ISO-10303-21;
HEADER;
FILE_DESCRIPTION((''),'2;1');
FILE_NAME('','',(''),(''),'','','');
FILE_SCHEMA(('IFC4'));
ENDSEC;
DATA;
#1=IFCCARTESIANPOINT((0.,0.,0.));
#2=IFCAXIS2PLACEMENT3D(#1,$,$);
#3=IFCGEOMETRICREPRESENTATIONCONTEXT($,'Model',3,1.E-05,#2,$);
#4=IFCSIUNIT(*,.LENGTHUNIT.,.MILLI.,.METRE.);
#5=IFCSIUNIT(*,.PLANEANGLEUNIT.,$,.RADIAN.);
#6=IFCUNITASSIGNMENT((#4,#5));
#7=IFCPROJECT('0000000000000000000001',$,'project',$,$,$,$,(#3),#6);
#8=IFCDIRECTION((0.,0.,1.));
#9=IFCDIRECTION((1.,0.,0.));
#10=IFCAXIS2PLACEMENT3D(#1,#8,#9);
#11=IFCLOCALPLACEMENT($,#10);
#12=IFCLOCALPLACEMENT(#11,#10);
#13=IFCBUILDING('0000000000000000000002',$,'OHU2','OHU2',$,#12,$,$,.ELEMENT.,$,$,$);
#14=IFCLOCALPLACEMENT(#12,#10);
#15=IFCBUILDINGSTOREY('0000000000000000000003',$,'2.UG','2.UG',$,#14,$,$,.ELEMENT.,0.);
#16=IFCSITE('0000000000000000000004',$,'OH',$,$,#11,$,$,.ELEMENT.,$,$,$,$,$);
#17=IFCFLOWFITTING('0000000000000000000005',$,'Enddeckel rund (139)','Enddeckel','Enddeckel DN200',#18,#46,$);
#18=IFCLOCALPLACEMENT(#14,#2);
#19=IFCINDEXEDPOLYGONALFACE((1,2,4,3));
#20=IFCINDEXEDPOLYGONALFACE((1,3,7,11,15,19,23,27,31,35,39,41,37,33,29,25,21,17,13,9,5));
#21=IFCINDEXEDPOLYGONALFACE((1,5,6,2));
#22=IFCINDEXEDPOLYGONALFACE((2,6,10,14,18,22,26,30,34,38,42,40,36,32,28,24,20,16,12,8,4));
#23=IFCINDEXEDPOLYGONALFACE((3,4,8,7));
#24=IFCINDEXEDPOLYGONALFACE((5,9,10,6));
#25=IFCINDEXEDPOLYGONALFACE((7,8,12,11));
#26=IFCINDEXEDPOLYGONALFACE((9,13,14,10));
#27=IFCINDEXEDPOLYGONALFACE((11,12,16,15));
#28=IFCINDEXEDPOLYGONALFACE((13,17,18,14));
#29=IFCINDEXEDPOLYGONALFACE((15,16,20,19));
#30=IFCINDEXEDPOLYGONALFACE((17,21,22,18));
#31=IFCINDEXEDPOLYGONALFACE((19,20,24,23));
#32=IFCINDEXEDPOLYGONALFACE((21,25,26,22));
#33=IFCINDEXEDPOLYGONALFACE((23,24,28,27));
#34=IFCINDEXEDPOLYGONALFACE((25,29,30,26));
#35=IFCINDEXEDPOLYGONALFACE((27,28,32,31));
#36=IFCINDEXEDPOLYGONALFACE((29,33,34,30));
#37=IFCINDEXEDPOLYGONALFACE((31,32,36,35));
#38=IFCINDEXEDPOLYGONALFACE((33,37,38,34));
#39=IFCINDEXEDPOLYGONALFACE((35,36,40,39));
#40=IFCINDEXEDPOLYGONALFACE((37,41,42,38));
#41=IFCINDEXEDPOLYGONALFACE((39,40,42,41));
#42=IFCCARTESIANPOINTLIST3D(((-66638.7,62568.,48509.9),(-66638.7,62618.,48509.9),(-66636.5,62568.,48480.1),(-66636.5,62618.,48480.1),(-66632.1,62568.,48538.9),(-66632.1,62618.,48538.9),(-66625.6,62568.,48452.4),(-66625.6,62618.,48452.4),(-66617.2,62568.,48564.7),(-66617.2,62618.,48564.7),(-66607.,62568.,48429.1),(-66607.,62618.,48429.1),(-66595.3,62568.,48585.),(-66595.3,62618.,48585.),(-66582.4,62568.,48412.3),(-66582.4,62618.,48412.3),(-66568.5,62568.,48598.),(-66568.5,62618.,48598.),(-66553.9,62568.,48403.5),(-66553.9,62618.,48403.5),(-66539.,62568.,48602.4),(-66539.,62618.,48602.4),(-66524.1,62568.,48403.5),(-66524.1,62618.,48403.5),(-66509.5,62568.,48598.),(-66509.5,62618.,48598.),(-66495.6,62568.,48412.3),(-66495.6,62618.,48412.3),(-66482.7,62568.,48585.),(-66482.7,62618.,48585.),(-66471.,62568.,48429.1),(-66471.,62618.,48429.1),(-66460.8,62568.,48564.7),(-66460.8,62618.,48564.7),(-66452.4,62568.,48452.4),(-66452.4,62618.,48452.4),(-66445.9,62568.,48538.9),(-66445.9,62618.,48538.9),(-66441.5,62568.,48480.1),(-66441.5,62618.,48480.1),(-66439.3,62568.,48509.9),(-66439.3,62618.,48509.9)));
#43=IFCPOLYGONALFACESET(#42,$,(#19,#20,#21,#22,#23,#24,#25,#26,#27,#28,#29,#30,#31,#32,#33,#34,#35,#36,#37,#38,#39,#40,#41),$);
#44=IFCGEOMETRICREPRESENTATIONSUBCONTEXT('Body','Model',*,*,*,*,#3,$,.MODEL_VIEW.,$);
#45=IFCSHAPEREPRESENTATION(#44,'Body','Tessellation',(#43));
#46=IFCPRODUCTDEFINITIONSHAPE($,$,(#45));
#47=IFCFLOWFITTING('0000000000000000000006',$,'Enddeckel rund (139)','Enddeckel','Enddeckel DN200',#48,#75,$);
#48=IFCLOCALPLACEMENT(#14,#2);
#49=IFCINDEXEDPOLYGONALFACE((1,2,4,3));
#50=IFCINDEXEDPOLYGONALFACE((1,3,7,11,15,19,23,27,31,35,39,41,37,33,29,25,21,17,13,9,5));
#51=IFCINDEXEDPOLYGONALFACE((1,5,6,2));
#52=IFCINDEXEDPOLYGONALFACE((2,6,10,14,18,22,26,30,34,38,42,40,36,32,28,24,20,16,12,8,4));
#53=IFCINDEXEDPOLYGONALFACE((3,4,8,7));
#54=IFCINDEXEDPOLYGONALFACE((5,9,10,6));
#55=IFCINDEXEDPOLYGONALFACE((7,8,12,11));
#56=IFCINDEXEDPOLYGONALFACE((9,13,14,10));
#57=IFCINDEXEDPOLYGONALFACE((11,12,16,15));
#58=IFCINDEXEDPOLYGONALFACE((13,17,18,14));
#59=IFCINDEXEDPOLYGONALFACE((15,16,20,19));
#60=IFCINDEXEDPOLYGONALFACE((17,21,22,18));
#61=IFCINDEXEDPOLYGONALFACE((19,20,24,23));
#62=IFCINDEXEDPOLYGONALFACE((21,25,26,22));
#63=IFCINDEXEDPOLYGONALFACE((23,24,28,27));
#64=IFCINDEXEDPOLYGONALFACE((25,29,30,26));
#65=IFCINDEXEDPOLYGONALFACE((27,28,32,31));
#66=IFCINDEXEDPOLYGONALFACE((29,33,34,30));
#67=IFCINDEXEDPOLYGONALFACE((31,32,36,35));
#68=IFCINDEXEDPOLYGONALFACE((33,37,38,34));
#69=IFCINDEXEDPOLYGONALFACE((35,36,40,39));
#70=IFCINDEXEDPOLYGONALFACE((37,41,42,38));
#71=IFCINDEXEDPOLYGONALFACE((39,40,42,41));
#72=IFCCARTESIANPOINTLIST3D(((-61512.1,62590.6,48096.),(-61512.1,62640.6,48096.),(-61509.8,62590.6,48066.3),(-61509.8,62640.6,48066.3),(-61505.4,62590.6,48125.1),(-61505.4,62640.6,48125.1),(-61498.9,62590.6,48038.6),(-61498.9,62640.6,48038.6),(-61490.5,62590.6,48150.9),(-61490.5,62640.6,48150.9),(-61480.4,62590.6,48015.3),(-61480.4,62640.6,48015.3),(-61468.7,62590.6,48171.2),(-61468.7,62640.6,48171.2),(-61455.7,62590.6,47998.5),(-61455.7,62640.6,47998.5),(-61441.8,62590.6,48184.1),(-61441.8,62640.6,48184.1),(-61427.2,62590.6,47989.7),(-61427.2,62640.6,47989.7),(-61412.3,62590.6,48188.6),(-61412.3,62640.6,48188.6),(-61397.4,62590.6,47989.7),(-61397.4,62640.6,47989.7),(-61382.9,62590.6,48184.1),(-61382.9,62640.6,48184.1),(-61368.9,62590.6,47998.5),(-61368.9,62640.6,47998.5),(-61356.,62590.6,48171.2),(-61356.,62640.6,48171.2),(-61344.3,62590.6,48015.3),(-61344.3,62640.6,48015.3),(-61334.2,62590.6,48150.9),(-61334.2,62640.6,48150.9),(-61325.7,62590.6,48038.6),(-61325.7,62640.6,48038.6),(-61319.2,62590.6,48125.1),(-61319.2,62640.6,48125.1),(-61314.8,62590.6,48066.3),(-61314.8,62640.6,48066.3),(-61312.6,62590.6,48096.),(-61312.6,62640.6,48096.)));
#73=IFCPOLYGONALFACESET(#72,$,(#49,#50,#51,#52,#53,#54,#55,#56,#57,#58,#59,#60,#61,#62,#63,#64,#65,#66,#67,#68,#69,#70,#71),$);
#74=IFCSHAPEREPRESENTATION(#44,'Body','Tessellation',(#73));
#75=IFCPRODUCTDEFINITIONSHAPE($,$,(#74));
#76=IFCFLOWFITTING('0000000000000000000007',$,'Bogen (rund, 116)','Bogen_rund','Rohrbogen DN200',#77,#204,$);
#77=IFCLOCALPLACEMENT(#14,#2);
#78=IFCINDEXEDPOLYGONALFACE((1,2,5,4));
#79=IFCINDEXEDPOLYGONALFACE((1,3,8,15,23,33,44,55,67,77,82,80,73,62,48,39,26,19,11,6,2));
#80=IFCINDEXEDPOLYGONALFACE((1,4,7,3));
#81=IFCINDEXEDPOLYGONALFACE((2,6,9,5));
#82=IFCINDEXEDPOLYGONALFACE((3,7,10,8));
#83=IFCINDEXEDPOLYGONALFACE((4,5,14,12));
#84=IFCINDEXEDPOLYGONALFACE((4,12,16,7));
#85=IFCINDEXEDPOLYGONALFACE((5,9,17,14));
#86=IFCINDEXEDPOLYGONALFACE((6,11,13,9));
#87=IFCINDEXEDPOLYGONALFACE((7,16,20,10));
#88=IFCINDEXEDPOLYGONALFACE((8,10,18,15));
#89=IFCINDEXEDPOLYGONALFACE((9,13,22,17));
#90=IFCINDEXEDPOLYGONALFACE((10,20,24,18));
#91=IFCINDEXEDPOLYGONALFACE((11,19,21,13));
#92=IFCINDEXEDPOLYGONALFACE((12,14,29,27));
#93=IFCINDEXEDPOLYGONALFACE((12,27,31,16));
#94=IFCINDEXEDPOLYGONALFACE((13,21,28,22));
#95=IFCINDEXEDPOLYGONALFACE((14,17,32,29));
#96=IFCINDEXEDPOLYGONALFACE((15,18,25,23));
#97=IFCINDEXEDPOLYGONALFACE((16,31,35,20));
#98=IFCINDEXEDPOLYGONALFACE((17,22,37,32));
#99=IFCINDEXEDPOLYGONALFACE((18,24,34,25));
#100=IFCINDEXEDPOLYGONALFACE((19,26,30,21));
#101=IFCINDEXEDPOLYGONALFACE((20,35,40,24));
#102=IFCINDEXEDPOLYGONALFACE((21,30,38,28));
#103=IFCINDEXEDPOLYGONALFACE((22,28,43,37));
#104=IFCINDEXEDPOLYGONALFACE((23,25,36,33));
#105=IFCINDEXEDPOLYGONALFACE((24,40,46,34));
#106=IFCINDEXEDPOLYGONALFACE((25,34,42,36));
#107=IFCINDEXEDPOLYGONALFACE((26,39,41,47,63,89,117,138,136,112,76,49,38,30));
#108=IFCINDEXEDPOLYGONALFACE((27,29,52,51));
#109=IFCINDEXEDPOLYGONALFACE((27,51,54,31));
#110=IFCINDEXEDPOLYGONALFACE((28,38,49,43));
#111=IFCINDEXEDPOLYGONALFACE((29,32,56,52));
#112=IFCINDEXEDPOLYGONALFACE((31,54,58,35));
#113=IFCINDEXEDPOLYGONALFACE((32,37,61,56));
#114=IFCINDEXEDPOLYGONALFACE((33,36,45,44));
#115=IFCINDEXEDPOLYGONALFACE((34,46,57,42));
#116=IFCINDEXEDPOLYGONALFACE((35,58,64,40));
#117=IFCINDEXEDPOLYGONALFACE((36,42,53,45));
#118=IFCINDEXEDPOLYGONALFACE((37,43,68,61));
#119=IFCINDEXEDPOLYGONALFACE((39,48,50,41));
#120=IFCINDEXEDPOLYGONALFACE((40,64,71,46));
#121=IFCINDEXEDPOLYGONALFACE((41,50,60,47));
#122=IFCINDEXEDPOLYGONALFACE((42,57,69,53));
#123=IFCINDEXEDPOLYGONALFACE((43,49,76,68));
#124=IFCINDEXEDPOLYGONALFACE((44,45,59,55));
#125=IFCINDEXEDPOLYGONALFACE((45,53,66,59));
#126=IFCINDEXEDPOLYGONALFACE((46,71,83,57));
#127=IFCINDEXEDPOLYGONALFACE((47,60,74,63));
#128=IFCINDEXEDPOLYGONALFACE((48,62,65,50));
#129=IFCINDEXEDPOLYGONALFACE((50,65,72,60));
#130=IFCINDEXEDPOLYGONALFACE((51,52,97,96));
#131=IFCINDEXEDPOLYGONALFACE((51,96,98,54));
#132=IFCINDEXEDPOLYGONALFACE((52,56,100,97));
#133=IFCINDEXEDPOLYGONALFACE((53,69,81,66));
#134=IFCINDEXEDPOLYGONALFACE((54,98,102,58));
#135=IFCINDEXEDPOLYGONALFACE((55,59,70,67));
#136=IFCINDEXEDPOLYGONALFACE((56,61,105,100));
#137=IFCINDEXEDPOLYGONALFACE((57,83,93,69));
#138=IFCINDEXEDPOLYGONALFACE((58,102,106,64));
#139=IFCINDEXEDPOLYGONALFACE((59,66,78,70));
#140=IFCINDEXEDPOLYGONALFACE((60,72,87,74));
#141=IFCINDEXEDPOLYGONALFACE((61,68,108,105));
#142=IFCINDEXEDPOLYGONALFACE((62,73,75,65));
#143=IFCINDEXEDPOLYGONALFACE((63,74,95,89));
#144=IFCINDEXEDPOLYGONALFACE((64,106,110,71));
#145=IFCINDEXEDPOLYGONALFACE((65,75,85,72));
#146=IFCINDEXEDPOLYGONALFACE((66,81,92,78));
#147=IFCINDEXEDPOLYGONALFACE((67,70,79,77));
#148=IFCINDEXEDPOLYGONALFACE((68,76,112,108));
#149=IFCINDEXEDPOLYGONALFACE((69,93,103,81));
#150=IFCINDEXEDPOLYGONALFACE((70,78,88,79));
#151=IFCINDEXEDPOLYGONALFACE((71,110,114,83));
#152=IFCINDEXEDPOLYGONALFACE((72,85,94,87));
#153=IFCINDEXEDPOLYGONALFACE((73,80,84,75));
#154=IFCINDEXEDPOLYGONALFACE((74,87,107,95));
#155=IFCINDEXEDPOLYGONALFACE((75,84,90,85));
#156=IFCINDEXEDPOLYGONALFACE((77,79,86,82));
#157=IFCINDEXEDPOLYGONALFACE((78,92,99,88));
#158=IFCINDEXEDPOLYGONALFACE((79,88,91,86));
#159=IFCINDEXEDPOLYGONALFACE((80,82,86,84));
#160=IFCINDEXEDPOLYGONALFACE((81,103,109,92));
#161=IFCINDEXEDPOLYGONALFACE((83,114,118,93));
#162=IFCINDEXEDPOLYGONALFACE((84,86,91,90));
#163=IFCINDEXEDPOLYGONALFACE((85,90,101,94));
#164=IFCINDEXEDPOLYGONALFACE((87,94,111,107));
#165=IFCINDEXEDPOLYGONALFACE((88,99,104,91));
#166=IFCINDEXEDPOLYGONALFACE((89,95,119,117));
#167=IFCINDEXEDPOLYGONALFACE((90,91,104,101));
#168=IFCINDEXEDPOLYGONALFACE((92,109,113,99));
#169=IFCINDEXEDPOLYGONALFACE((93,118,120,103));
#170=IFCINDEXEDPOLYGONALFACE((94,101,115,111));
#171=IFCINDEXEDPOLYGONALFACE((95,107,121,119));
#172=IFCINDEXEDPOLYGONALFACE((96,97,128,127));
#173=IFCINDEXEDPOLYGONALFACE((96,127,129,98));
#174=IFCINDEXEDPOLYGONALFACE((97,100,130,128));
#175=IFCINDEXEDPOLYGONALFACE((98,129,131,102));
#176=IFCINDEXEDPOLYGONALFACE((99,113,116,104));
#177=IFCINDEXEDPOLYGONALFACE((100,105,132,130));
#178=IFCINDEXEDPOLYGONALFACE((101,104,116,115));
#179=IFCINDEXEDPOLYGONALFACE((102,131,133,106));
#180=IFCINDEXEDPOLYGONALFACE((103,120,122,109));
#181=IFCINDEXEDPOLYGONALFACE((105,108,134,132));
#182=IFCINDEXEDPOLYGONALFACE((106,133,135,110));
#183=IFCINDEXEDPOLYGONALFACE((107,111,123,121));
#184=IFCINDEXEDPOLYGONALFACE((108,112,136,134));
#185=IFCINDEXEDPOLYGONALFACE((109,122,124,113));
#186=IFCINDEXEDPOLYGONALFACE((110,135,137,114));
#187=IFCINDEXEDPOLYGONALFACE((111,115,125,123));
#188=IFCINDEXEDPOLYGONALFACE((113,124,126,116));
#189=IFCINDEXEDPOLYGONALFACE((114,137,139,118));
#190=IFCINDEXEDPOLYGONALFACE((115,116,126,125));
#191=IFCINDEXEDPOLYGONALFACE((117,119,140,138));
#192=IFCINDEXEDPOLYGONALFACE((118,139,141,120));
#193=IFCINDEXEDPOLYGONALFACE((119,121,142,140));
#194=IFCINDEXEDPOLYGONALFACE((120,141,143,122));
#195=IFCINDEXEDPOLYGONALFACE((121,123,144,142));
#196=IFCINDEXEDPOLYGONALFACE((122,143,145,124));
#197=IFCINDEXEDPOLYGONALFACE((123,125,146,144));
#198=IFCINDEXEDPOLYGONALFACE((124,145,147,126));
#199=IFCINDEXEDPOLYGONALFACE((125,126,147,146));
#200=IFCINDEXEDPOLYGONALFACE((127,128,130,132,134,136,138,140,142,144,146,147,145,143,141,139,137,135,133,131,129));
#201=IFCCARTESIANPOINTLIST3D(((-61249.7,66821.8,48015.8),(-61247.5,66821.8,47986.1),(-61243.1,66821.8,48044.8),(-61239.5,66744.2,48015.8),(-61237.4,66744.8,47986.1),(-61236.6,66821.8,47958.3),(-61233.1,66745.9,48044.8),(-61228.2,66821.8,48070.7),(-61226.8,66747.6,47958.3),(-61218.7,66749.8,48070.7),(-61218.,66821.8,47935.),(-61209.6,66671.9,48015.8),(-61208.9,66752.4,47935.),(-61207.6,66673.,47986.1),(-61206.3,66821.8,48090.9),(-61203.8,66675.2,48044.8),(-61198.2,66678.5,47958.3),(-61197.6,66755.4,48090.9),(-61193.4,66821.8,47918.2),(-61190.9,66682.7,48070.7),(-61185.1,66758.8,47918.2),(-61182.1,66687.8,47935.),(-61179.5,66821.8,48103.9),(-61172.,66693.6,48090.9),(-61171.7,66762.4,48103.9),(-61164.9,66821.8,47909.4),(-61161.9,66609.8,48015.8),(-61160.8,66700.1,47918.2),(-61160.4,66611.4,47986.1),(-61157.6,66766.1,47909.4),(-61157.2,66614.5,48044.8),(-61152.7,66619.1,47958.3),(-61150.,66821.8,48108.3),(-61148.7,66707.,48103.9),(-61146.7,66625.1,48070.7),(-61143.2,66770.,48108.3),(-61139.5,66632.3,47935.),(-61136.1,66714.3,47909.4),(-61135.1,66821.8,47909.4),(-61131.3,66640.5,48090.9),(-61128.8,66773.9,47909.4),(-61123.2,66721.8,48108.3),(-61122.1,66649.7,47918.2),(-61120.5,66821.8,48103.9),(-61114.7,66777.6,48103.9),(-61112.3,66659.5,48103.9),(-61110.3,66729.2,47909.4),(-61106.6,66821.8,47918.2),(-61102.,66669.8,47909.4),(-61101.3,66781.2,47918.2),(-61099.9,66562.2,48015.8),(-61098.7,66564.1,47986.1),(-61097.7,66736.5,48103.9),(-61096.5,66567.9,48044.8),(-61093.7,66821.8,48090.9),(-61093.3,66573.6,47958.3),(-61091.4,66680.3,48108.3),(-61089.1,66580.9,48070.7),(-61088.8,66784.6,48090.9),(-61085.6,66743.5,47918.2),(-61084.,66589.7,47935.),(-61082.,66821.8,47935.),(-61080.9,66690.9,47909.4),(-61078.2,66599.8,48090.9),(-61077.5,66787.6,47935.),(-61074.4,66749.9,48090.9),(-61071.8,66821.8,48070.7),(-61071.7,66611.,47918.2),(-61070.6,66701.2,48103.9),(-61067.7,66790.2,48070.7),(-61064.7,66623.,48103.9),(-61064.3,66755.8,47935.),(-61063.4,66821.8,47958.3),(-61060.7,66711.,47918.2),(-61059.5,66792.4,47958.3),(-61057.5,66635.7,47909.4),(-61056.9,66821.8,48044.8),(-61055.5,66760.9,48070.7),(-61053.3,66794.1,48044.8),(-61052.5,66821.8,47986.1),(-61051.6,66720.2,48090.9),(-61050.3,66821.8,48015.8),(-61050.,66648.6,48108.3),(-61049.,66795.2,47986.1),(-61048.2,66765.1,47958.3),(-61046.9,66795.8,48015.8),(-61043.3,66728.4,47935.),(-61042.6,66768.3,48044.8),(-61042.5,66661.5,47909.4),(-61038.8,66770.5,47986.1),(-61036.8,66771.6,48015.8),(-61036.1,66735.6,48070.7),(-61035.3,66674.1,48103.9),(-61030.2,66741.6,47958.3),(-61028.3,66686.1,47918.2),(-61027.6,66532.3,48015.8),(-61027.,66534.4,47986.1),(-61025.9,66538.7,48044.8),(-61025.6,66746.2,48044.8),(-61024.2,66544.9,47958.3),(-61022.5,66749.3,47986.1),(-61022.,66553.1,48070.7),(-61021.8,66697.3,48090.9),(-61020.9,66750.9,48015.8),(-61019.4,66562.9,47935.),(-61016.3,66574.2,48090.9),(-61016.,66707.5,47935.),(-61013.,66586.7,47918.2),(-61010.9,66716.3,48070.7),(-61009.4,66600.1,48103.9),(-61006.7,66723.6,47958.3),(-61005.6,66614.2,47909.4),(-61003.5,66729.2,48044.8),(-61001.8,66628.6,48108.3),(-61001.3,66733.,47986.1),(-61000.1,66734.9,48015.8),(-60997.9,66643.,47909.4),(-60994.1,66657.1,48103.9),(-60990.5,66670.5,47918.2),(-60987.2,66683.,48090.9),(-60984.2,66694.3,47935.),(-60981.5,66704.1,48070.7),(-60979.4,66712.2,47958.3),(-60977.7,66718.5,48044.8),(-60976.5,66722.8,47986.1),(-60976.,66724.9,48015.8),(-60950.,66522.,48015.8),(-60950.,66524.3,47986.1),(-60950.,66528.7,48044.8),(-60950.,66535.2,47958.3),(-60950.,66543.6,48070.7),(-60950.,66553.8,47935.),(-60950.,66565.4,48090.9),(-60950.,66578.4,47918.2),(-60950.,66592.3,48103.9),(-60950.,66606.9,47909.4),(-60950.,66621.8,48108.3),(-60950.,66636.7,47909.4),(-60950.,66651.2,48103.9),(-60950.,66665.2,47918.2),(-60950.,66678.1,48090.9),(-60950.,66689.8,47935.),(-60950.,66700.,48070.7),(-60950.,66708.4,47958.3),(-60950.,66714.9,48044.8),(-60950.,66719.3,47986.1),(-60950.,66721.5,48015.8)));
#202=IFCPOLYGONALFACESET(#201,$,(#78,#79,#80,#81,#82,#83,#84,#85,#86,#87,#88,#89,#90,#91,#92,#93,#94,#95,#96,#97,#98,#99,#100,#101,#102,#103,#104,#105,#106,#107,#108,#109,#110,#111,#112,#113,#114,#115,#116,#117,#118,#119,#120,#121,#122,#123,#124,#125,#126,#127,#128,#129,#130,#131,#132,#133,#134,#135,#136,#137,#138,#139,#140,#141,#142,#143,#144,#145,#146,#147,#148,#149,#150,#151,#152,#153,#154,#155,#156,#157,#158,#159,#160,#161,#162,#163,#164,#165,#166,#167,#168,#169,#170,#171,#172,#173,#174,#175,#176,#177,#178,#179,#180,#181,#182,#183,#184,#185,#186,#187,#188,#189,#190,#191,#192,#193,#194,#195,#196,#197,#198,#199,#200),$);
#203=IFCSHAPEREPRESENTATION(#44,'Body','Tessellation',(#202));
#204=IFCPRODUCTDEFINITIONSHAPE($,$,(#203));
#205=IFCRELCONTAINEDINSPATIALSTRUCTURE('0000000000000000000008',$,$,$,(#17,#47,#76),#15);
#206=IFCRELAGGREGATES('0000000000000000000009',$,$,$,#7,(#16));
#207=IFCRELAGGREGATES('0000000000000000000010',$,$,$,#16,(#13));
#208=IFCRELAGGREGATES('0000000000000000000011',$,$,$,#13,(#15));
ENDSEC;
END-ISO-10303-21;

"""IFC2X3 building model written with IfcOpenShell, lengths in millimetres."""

from ifc_helpers import new_model, entity, si_unit, frame, origin, origin_with_axes, origin_2d_with_axis, place, context, subcontext, project, spatial, circle, extrude, element, save


model = new_model("IFC2X3")

# Units and contexts
model_context = context("Model", 3, precision=1e-05, world=origin())
body_context = subcontext(model_context, "Body", "Model", "MODEL_VIEW")
ifc_project = project(units=[si_unit("LENGTHUNIT", "METRE", prefix="MILLI"), si_unit("PLANEANGLEUNIT", "RADIAN")], contexts=[model_context])

# Site, building, storey
site_placement = place(None, origin_with_axes())
site = spatial("IfcSite", under=ifc_project, at=site_placement, Name="OH", CompositionType="ELEMENT")
building_placement = place(site_placement, origin_with_axes())
building = spatial("IfcBuilding", under=site, at=building_placement, Name="OHU2", Description="OHU2", CompositionType="ELEMENT")
storey_placement = place(building_placement, origin_with_axes())
storey = spatial("IfcBuildingStorey", under=building, at=storey_placement, Name="2.UG", Description="2.UG", CompositionType="ELEMENT", Elevation=0.0)

# Flow fittings
flow_fitting_1_placement = place(storey_placement, frame((-66539.2, 62593.0, 48502.4), z_axis=(0.0, 0.0, 1.0), x_axis=(1.0, 0.0, 0.0)))
element("IfcFlowFitting", 1, at=flow_fitting_1_placement, inside=storey, Name="Enddeckel rund (139)", Description="Enddeckel", ObjectType="Enddeckel DN200", context=body_context, shape_type="SweptSolid", body=[
    extrude(circle(Radius=100.0, at=origin_2d_with_axis()), frame((0.2, 25.0, 0.0), z_axis=(0.0, -1.0, 0.0), x_axis=(0.0, 0.0, 1.0)), (0.0, 0.0, 1.0), 50.0),
])
flow_fitting_2_placement = place(storey_placement, frame((-61412.5, 62615.6, 48088.6), z_axis=(0.0, 0.0, 1.0), x_axis=(1.0, 0.0, 0.0)))
element("IfcFlowFitting", 2, at=flow_fitting_2_placement, inside=storey, Name="Enddeckel rund (139)", Description="Enddeckel", ObjectType="Enddeckel DN200", context=body_context, shape_type="SweptSolid", body=[
    extrude(circle(Radius=100.0, at=origin_2d_with_axis()), frame((0.2, 25.0, 0.0), z_axis=(-0.000003, -1.0, 0.0), x_axis=(0.0, 0.0, 1.0)), (0.0, 0.0, 1.0), 50.0),
])
flow_fitting_3_placement = place(storey_placement, frame((-61100.0, 66671.8, 48008.3), z_axis=(0.0, 0.0, 1.0), x_axis=(1.0, 0.0, 0.0)))
element("IfcFlowFitting", 3, at=flow_fitting_3_placement, inside=storey, Name="Bogen (rund, 116)", Description="Bogen_rund", ObjectType="Rohrbogen DN200", context=body_context, shape_type="SweptSolid", body=[
    entity("IfcRevolvedAreaSolid", entity("IfcCircleProfileDef", "AREA", None, entity("IfcAxis2Placement2D", entity("IfcCartesianPoint", [0.0, 0.0]), entity("IfcDirection", [1.0, 0.0])), 100.0), entity("IfcAxis2Placement3D", entity("IfcCartesianPoint", [150.0, -50.0, 0.0]), entity("IfcDirection", [-1.0, 0.0, 0.0]), entity("IfcDirection", [0.0, 0.0, 1.0])), entity("IfcAxis1Placement", entity("IfcCartesianPoint", [0.0, 200.0, 0.0]), entity("IfcDirection", [-1.0, 0.0, 0.0])), 1.570796),
])

save(model, "model.ifc")
